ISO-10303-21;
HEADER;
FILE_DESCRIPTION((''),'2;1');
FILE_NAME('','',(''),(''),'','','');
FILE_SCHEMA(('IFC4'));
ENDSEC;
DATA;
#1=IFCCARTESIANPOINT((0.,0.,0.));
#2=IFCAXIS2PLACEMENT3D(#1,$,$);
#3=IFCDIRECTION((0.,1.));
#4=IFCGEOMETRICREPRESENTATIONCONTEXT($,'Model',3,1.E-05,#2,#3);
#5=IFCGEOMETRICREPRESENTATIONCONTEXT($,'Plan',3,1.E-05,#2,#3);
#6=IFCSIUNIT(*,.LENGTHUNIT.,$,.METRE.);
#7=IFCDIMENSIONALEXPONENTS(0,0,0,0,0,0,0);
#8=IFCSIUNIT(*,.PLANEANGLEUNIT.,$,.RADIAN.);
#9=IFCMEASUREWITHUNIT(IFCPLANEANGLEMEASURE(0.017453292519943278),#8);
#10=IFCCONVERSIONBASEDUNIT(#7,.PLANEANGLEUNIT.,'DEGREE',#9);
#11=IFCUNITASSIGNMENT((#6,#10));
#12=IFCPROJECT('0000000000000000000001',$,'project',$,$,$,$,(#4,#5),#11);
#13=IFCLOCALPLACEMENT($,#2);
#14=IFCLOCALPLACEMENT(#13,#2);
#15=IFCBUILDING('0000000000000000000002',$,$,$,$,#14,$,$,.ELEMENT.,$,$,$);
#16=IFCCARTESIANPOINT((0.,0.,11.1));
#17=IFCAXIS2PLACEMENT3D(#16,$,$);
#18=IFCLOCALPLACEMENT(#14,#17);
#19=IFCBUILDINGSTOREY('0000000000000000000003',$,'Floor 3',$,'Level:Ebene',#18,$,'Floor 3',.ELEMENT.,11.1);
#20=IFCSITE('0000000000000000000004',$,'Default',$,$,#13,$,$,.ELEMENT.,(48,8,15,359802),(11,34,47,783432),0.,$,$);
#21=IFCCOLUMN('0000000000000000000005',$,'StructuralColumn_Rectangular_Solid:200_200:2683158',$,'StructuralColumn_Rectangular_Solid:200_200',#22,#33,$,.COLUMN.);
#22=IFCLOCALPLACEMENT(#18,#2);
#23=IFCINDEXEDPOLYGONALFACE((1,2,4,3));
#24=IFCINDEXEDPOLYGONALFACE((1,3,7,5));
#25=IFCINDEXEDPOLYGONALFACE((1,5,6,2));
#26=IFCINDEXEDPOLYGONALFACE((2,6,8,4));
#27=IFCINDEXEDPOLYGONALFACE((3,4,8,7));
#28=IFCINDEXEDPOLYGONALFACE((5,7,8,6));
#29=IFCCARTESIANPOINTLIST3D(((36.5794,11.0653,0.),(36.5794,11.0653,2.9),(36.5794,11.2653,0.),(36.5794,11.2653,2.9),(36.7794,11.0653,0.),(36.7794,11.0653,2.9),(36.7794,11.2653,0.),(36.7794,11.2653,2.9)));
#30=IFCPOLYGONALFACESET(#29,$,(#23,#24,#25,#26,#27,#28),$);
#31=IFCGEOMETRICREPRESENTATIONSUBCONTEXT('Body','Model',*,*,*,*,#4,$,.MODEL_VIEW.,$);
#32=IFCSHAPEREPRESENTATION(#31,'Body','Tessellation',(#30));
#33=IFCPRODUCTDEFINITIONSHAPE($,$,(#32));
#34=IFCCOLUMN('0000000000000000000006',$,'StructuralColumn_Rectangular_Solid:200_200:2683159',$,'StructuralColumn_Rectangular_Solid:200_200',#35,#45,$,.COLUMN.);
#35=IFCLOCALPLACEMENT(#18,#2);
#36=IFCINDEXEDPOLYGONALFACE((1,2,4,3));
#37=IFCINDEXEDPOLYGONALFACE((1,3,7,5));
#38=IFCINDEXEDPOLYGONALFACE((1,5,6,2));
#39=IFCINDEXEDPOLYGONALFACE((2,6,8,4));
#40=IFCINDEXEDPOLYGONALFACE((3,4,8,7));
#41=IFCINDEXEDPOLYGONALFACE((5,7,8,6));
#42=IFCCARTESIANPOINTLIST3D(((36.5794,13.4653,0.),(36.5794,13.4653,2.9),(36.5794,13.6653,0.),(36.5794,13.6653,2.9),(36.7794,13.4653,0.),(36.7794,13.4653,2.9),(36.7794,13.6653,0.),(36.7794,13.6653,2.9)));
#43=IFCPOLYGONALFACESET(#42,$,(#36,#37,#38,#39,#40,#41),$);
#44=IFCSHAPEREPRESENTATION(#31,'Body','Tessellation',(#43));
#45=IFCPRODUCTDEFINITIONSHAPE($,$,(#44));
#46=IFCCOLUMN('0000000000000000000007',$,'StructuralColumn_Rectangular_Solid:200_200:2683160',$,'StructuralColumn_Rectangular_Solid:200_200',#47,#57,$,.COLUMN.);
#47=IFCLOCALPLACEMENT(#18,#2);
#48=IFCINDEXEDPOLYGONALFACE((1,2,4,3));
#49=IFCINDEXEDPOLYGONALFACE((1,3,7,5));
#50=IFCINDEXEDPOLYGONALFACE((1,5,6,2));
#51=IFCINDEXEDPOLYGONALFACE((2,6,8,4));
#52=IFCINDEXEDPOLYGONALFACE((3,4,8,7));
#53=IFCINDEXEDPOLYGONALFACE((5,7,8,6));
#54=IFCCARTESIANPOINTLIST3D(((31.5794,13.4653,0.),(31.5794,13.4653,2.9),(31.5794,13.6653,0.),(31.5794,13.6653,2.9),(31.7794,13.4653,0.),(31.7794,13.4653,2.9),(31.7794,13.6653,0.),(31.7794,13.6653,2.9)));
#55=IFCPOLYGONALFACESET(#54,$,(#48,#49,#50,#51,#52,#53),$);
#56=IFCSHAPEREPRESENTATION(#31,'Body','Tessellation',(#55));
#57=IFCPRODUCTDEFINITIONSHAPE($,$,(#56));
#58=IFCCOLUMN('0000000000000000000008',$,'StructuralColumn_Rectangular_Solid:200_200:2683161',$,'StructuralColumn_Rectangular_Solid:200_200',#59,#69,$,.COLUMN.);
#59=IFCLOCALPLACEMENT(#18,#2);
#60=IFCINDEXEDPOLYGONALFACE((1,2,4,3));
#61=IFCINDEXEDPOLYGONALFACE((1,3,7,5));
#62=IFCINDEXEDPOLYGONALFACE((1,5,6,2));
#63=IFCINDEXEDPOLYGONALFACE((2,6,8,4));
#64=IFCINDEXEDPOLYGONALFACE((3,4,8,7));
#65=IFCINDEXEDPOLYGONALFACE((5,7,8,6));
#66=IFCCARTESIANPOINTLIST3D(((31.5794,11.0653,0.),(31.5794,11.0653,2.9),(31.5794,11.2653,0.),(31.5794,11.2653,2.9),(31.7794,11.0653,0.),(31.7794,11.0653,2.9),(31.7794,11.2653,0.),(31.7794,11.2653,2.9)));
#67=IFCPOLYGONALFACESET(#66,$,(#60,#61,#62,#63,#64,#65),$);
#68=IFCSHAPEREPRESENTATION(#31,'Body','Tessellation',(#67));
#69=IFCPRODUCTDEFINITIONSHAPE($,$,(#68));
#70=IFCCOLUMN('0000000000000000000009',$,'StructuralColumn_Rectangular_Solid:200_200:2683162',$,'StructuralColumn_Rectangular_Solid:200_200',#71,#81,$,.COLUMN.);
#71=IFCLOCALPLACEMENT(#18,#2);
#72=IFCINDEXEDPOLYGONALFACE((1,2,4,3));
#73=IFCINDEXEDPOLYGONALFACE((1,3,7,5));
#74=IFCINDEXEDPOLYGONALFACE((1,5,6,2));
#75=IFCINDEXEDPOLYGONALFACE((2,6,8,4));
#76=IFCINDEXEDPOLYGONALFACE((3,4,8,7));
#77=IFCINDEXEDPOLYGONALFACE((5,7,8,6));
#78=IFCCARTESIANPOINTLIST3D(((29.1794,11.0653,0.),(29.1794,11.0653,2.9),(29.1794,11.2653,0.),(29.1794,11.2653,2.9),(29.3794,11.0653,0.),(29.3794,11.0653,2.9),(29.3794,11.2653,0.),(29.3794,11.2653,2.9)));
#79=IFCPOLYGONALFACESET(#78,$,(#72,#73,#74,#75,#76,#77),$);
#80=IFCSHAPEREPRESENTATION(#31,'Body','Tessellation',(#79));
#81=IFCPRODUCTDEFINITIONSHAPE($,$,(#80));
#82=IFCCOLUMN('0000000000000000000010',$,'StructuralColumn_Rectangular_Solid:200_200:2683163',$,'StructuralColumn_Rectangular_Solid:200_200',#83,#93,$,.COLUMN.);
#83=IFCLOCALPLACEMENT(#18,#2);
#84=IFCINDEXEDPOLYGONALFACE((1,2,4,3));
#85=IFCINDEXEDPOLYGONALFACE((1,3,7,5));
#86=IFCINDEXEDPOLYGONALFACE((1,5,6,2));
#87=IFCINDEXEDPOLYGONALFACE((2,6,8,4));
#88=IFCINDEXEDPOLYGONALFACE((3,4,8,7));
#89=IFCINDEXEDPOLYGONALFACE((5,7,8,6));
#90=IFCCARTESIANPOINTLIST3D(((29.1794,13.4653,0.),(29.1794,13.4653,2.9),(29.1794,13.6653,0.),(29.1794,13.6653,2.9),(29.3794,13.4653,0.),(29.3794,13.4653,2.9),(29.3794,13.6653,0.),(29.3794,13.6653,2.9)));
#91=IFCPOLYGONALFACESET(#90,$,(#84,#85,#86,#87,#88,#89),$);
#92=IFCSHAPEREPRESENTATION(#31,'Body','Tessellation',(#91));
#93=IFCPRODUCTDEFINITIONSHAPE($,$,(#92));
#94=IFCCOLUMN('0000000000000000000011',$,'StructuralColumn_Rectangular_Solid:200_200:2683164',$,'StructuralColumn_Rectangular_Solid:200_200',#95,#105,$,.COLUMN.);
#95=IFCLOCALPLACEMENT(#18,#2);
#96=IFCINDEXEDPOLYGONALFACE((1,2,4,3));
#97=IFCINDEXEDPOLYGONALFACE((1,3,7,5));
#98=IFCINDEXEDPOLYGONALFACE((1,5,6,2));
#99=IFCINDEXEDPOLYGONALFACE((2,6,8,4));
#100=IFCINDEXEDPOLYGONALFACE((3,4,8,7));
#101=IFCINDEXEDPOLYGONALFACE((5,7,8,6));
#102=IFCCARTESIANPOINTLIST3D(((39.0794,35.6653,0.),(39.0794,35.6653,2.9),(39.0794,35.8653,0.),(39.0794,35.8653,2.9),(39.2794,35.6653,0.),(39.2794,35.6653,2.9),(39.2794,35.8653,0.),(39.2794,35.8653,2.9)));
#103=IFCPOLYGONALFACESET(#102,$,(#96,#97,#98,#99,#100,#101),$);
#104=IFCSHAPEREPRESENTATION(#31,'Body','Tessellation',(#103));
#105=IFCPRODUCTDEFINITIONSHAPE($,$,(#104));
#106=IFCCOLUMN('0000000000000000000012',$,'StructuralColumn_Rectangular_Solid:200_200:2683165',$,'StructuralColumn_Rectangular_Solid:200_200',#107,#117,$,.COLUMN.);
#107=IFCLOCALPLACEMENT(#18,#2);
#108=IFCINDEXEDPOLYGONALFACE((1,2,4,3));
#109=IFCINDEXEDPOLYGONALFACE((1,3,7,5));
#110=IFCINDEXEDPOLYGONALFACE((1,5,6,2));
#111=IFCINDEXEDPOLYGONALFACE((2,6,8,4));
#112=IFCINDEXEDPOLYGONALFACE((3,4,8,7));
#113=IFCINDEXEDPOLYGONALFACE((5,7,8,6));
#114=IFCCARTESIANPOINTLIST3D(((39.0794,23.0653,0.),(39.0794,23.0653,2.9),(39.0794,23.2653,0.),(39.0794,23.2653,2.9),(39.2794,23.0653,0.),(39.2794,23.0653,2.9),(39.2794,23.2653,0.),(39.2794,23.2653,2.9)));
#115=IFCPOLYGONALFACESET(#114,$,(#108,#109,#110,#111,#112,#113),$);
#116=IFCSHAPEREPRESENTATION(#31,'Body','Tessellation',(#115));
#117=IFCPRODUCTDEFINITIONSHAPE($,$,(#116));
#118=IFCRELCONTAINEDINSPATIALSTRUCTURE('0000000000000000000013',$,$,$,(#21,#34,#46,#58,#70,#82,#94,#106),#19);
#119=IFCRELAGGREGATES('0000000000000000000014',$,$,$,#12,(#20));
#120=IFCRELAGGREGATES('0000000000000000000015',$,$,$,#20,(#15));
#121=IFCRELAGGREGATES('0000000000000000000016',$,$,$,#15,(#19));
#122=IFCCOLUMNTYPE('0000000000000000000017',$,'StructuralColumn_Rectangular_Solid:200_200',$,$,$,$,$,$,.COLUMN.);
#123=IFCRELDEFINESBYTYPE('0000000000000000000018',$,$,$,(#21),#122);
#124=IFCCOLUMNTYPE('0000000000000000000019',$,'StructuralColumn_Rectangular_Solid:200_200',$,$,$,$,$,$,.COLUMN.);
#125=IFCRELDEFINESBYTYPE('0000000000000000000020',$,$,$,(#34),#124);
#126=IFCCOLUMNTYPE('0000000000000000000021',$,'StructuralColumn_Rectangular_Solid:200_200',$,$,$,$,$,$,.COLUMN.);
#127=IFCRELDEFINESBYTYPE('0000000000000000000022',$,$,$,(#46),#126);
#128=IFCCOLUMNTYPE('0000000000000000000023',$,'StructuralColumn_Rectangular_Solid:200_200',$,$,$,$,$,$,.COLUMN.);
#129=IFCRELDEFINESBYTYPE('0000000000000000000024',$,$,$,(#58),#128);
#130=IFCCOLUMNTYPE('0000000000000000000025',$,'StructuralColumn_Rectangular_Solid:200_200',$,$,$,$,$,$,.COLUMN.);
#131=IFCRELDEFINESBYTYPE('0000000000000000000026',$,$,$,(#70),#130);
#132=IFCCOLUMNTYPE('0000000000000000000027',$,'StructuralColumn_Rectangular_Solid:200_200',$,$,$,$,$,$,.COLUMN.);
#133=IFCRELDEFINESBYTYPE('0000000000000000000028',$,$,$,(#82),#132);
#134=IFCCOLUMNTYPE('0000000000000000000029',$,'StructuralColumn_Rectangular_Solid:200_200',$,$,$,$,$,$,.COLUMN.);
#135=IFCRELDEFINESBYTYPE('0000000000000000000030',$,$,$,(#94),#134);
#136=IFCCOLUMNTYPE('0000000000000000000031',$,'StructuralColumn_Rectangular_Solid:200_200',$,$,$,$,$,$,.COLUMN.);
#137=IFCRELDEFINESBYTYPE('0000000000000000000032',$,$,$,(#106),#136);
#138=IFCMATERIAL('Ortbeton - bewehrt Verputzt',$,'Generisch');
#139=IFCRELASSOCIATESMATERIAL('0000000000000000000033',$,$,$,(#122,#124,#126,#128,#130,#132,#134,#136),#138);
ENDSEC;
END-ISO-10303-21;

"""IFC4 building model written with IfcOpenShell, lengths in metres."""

from ifc_helpers import new_model, entity, si_unit, converted_unit, direction, frame, frame_2d, origin, place, context, subcontext, project, spatial, rectangle, extrude, source, transform, mapped, material, material_profile, profile_set, type_object, type_shapes, element, save


model = new_model("IFC4")

# Units and contexts
model_context = context("Model", 3, precision=1e-05, world=origin(), true_north=direction((0.0, 1.0)))
plan_context = context("Plan", 3, precision=1e-05, world=origin(), true_north=direction((0.0, 1.0)))
body_context = subcontext(model_context, "Body", "Model", "MODEL_VIEW")
ifc_project = project(units=[si_unit("LENGTHUNIT", "METRE"), converted_unit("PLANEANGLEUNIT", "DEGREE", entity("IfcPlaneAngleMeasure", 0.017453292519943278), si_unit("PLANEANGLEUNIT", "RADIAN"), dimensions=[0, 0, 0, 0, 0, 0, 0])], contexts=[model_context, plan_context])

# Site, building, storey
site_placement = place(None, origin())
site = spatial("IfcSite", under=ifc_project, at=site_placement, Name="Default", CompositionType="ELEMENT", RefLatitude=(48, 8, 15, 359802), RefLongitude=(11, 34, 47, 783432), RefElevation=0.0)
building_placement = place(site_placement, origin())
building = spatial("IfcBuilding", under=site, at=building_placement, CompositionType="ELEMENT")
storey_placement = place(building_placement, frame((0.0, 0.0, 11.1)))
storey = spatial("IfcBuildingStorey", under=building, at=storey_placement, Name="Floor 3", ObjectType="Level:Ebene", LongName="Floor 3", CompositionType="ELEMENT", Elevation=11.1)

# Columns
ifc_material_1 = material(Name="Ortbeton - bewehrt Verputzt", Category="Generisch")
ifc_material_profile = material_profile(ifc_material_1, rectangle(XDim=0.2, YDim=0.2, at=frame_2d((0.0, 0.0), x_axis=(1.0, 0.0))), Name="200_200")
ifc_profile_set = profile_set([ifc_material_profile], Name="200_200")
column_type_1 = type_object("IfcColumnType", Name="StructuralColumn_Rectangular_Solid:200_200", PredefinedType="COLUMN", material=ifc_profile_set)
shared_shape_1 = source(origin(), body_context, "Body", "SweptSolid", [
    extrude(rectangle(XDim=0.2, YDim=0.2, at=frame_2d((0.0, 0.0), x_axis=(1.0, 0.0))), frame((36.6794, 11.1653, 11.1), z_axis=(0.0, 0.0, 1.0), x_axis=(-1.0, 0.0, 0.0)), (0.0, 0.0, 1.0), 2.9),
])
type_shapes(column_type_1, [shared_shape_1])
column_1_placement = place(storey_placement, frame((0.0, 0.0, -11.1)))
element("IfcColumn", 1, at=column_1_placement, inside=storey, type_object=column_type_1, Name="StructuralColumn_Rectangular_Solid:200_200:2683158", ObjectType="StructuralColumn_Rectangular_Solid:200_200", PredefinedType="COLUMN", context=body_context, shape_type="MappedRepresentation", body=[
    mapped(shared_shape_1, transform((0.0, 0.0, 0.0), scale=1.0)),
])
column_type_2 = type_object("IfcColumnType", Name="StructuralColumn_Rectangular_Solid:200_200", PredefinedType="COLUMN", material=ifc_profile_set)
shared_shape_2 = source(origin(), body_context, "Body", "SweptSolid", [
    extrude(rectangle(XDim=0.2, YDim=0.2, at=frame_2d((0.0, 0.0), x_axis=(1.0, 0.0))), frame((36.6794, 13.5653, 11.1), z_axis=(0.0, 0.0, 1.0), x_axis=(-1.0, 0.0, 0.0)), (0.0, 0.0, 1.0), 2.9),
])
type_shapes(column_type_2, [shared_shape_2])
column_2_placement = place(storey_placement, frame((0.0, 0.0, -11.1)))
element("IfcColumn", 2, at=column_2_placement, inside=storey, type_object=column_type_2, Name="StructuralColumn_Rectangular_Solid:200_200:2683159", ObjectType="StructuralColumn_Rectangular_Solid:200_200", PredefinedType="COLUMN", context=body_context, shape_type="MappedRepresentation", body=[
    mapped(shared_shape_2, transform((0.0, 0.0, 0.0), scale=1.0)),
])
column_type_3 = type_object("IfcColumnType", Name="StructuralColumn_Rectangular_Solid:200_200", PredefinedType="COLUMN", material=ifc_profile_set)
shared_shape_3 = source(origin(), body_context, "Body", "SweptSolid", [
    extrude(rectangle(XDim=0.2, YDim=0.2, at=frame_2d((0.0, 0.0), x_axis=(1.0, 0.0))), frame((31.6794, 13.5653, 11.1), z_axis=(0.0, 0.0, 1.0), x_axis=(-1.0, 0.0, 0.0)), (0.0, 0.0, 1.0), 2.9),
])
type_shapes(column_type_3, [shared_shape_3])
column_3_placement = place(storey_placement, frame((0.0, 0.0, -11.1)))
element("IfcColumn", 3, at=column_3_placement, inside=storey, type_object=column_type_3, Name="StructuralColumn_Rectangular_Solid:200_200:2683160", ObjectType="StructuralColumn_Rectangular_Solid:200_200", PredefinedType="COLUMN", context=body_context, shape_type="MappedRepresentation", body=[
    mapped(shared_shape_3, transform((0.0, 0.0, 0.0), scale=1.0)),
])
column_type_4 = type_object("IfcColumnType", Name="StructuralColumn_Rectangular_Solid:200_200", PredefinedType="COLUMN", material=ifc_profile_set)
shared_shape_4 = source(origin(), body_context, "Body", "SweptSolid", [
    extrude(rectangle(XDim=0.2, YDim=0.2, at=frame_2d((0.0, 0.0), x_axis=(1.0, 0.0))), frame((31.6794, 11.1653, 11.1), z_axis=(0.0, 0.0, 1.0), x_axis=(-1.0, 0.0, 0.0)), (0.0, 0.0, 1.0), 2.9),
])
type_shapes(column_type_4, [shared_shape_4])
column_4_placement = place(storey_placement, frame((0.0, 0.0, -11.1)))
element("IfcColumn", 4, at=column_4_placement, inside=storey, type_object=column_type_4, Name="StructuralColumn_Rectangular_Solid:200_200:2683161", ObjectType="StructuralColumn_Rectangular_Solid:200_200", PredefinedType="COLUMN", context=body_context, shape_type="MappedRepresentation", body=[
    mapped(shared_shape_4, transform((0.0, 0.0, 0.0), scale=1.0)),
])
column_type_5 = type_object("IfcColumnType", Name="StructuralColumn_Rectangular_Solid:200_200", PredefinedType="COLUMN", material=ifc_profile_set)
shared_shape_5 = source(origin(), body_context, "Body", "SweptSolid", [
    extrude(rectangle(XDim=0.2, YDim=0.2, at=frame_2d((0.0, 0.0), x_axis=(1.0, 0.0))), frame((29.2794, 11.1653, 11.1), z_axis=(0.0, 0.0, 1.0), x_axis=(-1.0, 0.0, 0.0)), (0.0, 0.0, 1.0), 2.9),
])
type_shapes(column_type_5, [shared_shape_5])
column_5_placement = place(storey_placement, frame((0.0, 0.0, -11.1)))
element("IfcColumn", 5, at=column_5_placement, inside=storey, type_object=column_type_5, Name="StructuralColumn_Rectangular_Solid:200_200:2683162", ObjectType="StructuralColumn_Rectangular_Solid:200_200", PredefinedType="COLUMN", context=body_context, shape_type="MappedRepresentation", body=[
    mapped(shared_shape_5, transform((0.0, 0.0, 0.0), scale=1.0)),
])
column_type_6 = type_object("IfcColumnType", Name="StructuralColumn_Rectangular_Solid:200_200", PredefinedType="COLUMN", material=ifc_profile_set)
shared_shape_6 = source(origin(), body_context, "Body", "SweptSolid", [
    extrude(rectangle(XDim=0.2, YDim=0.2, at=frame_2d((0.0, 0.0), x_axis=(1.0, 0.0))), frame((29.2794, 13.5653, 11.1), z_axis=(0.0, 0.0, 1.0), x_axis=(-1.0, 0.0, 0.0)), (0.0, 0.0, 1.0), 2.9),
])
type_shapes(column_type_6, [shared_shape_6])
column_6_placement = place(storey_placement, frame((0.0, 0.0, -11.1)))
element("IfcColumn", 6, at=column_6_placement, inside=storey, type_object=column_type_6, Name="StructuralColumn_Rectangular_Solid:200_200:2683163", ObjectType="StructuralColumn_Rectangular_Solid:200_200", PredefinedType="COLUMN", context=body_context, shape_type="MappedRepresentation", body=[
    mapped(shared_shape_6, transform((0.0, 0.0, 0.0), scale=1.0)),
])
column_type_7 = type_object("IfcColumnType", Name="StructuralColumn_Rectangular_Solid:200_200", PredefinedType="COLUMN", material=ifc_profile_set)
shared_shape_7 = source(origin(), body_context, "Body", "SweptSolid", [
    extrude(rectangle(XDim=0.2, YDim=0.2, at=frame_2d((0.0, 0.0), x_axis=(1.0, 0.0))), frame((39.1794, 35.7653, 11.1), z_axis=(0.0, 0.0, 1.0), x_axis=(-1.0, 0.0, 0.0)), (0.0, 0.0, 1.0), 2.9),
])
type_shapes(column_type_7, [shared_shape_7])
column_7_placement = place(storey_placement, frame((0.0, 0.0, -11.1)))
element("IfcColumn", 7, at=column_7_placement, inside=storey, type_object=column_type_7, Name="StructuralColumn_Rectangular_Solid:200_200:2683164", ObjectType="StructuralColumn_Rectangular_Solid:200_200", PredefinedType="COLUMN", context=body_context, shape_type="MappedRepresentation", body=[
    mapped(shared_shape_7, transform((0.0, 0.0, 0.0), scale=1.0)),
])
column_type_8 = type_object("IfcColumnType", Name="StructuralColumn_Rectangular_Solid:200_200", PredefinedType="COLUMN", material=ifc_profile_set)
shared_shape_8 = source(origin(), body_context, "Body", "SweptSolid", [
    extrude(rectangle(XDim=0.2, YDim=0.2, at=frame_2d((0.0, 0.0), x_axis=(1.0, 0.0))), frame((39.1794, 23.1653, 11.1), z_axis=(0.0, 0.0, 1.0), x_axis=(-1.0, 0.0, 0.0)), (0.0, 0.0, 1.0), 2.9),
])
type_shapes(column_type_8, [shared_shape_8])
column_8_placement = place(storey_placement, frame((0.0, 0.0, -11.1)))
element("IfcColumn", 8, at=column_8_placement, inside=storey, type_object=column_type_8, Name="StructuralColumn_Rectangular_Solid:200_200:2683165", ObjectType="StructuralColumn_Rectangular_Solid:200_200", PredefinedType="COLUMN", context=body_context, shape_type="MappedRepresentation", body=[
    mapped(shared_shape_8, transform((0.0, 0.0, 0.0), scale=1.0)),
])

save(model, "model.ifc")
